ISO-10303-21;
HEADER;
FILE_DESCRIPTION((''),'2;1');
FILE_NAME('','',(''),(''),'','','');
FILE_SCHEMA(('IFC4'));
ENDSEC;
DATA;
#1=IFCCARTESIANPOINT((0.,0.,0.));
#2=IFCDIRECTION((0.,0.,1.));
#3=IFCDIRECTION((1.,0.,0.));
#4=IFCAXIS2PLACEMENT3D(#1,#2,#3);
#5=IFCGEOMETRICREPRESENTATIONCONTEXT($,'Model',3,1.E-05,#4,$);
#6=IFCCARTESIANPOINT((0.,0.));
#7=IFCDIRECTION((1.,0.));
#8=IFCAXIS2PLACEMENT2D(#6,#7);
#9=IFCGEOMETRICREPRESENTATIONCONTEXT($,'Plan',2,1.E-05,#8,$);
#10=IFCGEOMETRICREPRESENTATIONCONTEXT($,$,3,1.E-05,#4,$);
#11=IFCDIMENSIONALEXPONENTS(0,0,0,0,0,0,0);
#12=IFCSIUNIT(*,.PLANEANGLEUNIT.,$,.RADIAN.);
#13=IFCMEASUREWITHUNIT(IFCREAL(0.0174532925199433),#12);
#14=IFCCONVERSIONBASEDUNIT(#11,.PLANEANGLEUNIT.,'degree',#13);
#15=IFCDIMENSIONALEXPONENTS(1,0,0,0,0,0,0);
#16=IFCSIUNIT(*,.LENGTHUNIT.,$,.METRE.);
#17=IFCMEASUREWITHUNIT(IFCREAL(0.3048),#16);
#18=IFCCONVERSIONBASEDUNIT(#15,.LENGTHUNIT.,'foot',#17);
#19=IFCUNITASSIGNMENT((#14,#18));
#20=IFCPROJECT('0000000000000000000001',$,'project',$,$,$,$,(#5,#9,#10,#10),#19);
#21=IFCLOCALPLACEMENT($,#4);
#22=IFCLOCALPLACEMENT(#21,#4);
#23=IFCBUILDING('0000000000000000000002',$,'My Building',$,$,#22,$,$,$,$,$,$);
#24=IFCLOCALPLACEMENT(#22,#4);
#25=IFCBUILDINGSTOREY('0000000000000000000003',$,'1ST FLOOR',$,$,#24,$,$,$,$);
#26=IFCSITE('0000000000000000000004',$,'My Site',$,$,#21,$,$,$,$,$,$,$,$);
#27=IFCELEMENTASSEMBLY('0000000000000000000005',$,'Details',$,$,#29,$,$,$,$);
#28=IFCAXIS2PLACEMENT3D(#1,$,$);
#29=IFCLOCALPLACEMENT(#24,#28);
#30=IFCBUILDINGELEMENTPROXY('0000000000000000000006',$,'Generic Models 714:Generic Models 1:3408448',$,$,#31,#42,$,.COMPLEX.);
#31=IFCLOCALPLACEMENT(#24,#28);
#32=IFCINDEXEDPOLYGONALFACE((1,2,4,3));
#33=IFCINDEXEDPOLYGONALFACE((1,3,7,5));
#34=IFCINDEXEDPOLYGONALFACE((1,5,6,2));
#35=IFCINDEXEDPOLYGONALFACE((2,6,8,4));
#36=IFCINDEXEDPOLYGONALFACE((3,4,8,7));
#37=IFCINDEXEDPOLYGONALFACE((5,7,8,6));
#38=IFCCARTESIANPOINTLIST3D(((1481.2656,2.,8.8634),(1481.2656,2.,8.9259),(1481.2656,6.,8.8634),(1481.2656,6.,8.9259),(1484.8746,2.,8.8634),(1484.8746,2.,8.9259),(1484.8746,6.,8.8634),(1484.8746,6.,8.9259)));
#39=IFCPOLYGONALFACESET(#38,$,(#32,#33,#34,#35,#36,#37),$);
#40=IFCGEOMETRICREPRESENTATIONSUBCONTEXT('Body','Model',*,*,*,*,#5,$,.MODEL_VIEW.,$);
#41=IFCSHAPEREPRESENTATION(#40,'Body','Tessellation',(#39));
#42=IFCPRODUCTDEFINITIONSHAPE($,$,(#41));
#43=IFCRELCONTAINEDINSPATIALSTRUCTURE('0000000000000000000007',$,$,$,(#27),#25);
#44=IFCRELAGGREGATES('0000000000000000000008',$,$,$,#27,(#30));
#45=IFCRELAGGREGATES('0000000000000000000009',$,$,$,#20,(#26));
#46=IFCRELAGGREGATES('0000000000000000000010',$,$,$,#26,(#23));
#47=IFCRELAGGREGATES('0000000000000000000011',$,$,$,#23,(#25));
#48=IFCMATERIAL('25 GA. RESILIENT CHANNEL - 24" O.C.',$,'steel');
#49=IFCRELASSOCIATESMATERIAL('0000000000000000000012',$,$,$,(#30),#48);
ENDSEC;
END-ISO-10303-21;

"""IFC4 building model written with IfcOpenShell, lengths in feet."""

from ifc_helpers import new_model, entity, si_unit, converted_unit, frame, origin_with_axes, origin_2d_with_axis, place, context, subcontext, project, spatial, polyline, outline, extrude, material, element, aggregate, save


model = new_model("IFC4")

# Units and contexts
model_context = context("Model", 3, precision=1e-05, world=origin_with_axes())
plan_context = context("Plan", 2, precision=1e-05, world=origin_2d_with_axis())
context_of_model = context(None, 3, precision=1e-05, world=origin_with_axes())
body_context = subcontext(model_context, "Body", "Model", "MODEL_VIEW")
ifc_project = project(units=[converted_unit("PLANEANGLEUNIT", "degree", entity("IfcReal", 0.0174532925199433), si_unit("PLANEANGLEUNIT", "RADIAN"), dimensions=[0, 0, 0, 0, 0, 0, 0]), converted_unit("LENGTHUNIT", "foot", entity("IfcReal", 0.3048), si_unit("LENGTHUNIT", "METRE"), dimensions=[1, 0, 0, 0, 0, 0, 0])], contexts=[model_context, plan_context, context_of_model, context_of_model])

# Site, building, storey
site_placement = place(None, origin_with_axes())
site = spatial("IfcSite", under=ifc_project, at=site_placement, Name="My Site")
building_placement = place(site_placement, origin_with_axes())
building = spatial("IfcBuilding", under=site, at=building_placement, Name="My Building")
storey_placement = place(building_placement, origin_with_axes())
storey = spatial("IfcBuildingStorey", under=building, at=storey_placement, Name="1ST FLOOR")

# Element assembly, building element proxy
assembly_placement = place(storey_placement, origin_with_axes())
assembly = element("IfcElementAssembly", 1, at=assembly_placement, inside=storey, Name="Details")
ifc_material_1 = material(Name="25 GA. RESILIENT CHANNEL - 24\" O.C.", Category="steel")
proxy_1_placement = place(assembly_placement, frame((1481.263, 6.0, 8.8634), z_axis=(0.0, -1.0, 0.0), x_axis=(0.0, 0.0, 1.0)))
proxy_1 = element("IfcBuildingElementProxy", 2, at=proxy_1_placement, material=ifc_material_1, Name="Generic Models 714:Generic Models 1:3408448", PredefinedType="COMPLEX", context=body_context, shape_type="SweptSolid", body=[
    extrude(outline(polyline([(-0.0313, -1.8045), (0.0312, -1.8045), (0.0313, 1.8045), (-0.0312, 1.8045), (-0.0313, -1.8045)])), frame((0.0313, -1.8072, 0.0), z_axis=(0.0, 0.0, -1.0), x_axis=(-1.0, 0.0, 0.0)), (0.0, 0.0, -1.0), 4.0),
])
aggregate(assembly, [proxy_1])

save(model, "model.ifc")
